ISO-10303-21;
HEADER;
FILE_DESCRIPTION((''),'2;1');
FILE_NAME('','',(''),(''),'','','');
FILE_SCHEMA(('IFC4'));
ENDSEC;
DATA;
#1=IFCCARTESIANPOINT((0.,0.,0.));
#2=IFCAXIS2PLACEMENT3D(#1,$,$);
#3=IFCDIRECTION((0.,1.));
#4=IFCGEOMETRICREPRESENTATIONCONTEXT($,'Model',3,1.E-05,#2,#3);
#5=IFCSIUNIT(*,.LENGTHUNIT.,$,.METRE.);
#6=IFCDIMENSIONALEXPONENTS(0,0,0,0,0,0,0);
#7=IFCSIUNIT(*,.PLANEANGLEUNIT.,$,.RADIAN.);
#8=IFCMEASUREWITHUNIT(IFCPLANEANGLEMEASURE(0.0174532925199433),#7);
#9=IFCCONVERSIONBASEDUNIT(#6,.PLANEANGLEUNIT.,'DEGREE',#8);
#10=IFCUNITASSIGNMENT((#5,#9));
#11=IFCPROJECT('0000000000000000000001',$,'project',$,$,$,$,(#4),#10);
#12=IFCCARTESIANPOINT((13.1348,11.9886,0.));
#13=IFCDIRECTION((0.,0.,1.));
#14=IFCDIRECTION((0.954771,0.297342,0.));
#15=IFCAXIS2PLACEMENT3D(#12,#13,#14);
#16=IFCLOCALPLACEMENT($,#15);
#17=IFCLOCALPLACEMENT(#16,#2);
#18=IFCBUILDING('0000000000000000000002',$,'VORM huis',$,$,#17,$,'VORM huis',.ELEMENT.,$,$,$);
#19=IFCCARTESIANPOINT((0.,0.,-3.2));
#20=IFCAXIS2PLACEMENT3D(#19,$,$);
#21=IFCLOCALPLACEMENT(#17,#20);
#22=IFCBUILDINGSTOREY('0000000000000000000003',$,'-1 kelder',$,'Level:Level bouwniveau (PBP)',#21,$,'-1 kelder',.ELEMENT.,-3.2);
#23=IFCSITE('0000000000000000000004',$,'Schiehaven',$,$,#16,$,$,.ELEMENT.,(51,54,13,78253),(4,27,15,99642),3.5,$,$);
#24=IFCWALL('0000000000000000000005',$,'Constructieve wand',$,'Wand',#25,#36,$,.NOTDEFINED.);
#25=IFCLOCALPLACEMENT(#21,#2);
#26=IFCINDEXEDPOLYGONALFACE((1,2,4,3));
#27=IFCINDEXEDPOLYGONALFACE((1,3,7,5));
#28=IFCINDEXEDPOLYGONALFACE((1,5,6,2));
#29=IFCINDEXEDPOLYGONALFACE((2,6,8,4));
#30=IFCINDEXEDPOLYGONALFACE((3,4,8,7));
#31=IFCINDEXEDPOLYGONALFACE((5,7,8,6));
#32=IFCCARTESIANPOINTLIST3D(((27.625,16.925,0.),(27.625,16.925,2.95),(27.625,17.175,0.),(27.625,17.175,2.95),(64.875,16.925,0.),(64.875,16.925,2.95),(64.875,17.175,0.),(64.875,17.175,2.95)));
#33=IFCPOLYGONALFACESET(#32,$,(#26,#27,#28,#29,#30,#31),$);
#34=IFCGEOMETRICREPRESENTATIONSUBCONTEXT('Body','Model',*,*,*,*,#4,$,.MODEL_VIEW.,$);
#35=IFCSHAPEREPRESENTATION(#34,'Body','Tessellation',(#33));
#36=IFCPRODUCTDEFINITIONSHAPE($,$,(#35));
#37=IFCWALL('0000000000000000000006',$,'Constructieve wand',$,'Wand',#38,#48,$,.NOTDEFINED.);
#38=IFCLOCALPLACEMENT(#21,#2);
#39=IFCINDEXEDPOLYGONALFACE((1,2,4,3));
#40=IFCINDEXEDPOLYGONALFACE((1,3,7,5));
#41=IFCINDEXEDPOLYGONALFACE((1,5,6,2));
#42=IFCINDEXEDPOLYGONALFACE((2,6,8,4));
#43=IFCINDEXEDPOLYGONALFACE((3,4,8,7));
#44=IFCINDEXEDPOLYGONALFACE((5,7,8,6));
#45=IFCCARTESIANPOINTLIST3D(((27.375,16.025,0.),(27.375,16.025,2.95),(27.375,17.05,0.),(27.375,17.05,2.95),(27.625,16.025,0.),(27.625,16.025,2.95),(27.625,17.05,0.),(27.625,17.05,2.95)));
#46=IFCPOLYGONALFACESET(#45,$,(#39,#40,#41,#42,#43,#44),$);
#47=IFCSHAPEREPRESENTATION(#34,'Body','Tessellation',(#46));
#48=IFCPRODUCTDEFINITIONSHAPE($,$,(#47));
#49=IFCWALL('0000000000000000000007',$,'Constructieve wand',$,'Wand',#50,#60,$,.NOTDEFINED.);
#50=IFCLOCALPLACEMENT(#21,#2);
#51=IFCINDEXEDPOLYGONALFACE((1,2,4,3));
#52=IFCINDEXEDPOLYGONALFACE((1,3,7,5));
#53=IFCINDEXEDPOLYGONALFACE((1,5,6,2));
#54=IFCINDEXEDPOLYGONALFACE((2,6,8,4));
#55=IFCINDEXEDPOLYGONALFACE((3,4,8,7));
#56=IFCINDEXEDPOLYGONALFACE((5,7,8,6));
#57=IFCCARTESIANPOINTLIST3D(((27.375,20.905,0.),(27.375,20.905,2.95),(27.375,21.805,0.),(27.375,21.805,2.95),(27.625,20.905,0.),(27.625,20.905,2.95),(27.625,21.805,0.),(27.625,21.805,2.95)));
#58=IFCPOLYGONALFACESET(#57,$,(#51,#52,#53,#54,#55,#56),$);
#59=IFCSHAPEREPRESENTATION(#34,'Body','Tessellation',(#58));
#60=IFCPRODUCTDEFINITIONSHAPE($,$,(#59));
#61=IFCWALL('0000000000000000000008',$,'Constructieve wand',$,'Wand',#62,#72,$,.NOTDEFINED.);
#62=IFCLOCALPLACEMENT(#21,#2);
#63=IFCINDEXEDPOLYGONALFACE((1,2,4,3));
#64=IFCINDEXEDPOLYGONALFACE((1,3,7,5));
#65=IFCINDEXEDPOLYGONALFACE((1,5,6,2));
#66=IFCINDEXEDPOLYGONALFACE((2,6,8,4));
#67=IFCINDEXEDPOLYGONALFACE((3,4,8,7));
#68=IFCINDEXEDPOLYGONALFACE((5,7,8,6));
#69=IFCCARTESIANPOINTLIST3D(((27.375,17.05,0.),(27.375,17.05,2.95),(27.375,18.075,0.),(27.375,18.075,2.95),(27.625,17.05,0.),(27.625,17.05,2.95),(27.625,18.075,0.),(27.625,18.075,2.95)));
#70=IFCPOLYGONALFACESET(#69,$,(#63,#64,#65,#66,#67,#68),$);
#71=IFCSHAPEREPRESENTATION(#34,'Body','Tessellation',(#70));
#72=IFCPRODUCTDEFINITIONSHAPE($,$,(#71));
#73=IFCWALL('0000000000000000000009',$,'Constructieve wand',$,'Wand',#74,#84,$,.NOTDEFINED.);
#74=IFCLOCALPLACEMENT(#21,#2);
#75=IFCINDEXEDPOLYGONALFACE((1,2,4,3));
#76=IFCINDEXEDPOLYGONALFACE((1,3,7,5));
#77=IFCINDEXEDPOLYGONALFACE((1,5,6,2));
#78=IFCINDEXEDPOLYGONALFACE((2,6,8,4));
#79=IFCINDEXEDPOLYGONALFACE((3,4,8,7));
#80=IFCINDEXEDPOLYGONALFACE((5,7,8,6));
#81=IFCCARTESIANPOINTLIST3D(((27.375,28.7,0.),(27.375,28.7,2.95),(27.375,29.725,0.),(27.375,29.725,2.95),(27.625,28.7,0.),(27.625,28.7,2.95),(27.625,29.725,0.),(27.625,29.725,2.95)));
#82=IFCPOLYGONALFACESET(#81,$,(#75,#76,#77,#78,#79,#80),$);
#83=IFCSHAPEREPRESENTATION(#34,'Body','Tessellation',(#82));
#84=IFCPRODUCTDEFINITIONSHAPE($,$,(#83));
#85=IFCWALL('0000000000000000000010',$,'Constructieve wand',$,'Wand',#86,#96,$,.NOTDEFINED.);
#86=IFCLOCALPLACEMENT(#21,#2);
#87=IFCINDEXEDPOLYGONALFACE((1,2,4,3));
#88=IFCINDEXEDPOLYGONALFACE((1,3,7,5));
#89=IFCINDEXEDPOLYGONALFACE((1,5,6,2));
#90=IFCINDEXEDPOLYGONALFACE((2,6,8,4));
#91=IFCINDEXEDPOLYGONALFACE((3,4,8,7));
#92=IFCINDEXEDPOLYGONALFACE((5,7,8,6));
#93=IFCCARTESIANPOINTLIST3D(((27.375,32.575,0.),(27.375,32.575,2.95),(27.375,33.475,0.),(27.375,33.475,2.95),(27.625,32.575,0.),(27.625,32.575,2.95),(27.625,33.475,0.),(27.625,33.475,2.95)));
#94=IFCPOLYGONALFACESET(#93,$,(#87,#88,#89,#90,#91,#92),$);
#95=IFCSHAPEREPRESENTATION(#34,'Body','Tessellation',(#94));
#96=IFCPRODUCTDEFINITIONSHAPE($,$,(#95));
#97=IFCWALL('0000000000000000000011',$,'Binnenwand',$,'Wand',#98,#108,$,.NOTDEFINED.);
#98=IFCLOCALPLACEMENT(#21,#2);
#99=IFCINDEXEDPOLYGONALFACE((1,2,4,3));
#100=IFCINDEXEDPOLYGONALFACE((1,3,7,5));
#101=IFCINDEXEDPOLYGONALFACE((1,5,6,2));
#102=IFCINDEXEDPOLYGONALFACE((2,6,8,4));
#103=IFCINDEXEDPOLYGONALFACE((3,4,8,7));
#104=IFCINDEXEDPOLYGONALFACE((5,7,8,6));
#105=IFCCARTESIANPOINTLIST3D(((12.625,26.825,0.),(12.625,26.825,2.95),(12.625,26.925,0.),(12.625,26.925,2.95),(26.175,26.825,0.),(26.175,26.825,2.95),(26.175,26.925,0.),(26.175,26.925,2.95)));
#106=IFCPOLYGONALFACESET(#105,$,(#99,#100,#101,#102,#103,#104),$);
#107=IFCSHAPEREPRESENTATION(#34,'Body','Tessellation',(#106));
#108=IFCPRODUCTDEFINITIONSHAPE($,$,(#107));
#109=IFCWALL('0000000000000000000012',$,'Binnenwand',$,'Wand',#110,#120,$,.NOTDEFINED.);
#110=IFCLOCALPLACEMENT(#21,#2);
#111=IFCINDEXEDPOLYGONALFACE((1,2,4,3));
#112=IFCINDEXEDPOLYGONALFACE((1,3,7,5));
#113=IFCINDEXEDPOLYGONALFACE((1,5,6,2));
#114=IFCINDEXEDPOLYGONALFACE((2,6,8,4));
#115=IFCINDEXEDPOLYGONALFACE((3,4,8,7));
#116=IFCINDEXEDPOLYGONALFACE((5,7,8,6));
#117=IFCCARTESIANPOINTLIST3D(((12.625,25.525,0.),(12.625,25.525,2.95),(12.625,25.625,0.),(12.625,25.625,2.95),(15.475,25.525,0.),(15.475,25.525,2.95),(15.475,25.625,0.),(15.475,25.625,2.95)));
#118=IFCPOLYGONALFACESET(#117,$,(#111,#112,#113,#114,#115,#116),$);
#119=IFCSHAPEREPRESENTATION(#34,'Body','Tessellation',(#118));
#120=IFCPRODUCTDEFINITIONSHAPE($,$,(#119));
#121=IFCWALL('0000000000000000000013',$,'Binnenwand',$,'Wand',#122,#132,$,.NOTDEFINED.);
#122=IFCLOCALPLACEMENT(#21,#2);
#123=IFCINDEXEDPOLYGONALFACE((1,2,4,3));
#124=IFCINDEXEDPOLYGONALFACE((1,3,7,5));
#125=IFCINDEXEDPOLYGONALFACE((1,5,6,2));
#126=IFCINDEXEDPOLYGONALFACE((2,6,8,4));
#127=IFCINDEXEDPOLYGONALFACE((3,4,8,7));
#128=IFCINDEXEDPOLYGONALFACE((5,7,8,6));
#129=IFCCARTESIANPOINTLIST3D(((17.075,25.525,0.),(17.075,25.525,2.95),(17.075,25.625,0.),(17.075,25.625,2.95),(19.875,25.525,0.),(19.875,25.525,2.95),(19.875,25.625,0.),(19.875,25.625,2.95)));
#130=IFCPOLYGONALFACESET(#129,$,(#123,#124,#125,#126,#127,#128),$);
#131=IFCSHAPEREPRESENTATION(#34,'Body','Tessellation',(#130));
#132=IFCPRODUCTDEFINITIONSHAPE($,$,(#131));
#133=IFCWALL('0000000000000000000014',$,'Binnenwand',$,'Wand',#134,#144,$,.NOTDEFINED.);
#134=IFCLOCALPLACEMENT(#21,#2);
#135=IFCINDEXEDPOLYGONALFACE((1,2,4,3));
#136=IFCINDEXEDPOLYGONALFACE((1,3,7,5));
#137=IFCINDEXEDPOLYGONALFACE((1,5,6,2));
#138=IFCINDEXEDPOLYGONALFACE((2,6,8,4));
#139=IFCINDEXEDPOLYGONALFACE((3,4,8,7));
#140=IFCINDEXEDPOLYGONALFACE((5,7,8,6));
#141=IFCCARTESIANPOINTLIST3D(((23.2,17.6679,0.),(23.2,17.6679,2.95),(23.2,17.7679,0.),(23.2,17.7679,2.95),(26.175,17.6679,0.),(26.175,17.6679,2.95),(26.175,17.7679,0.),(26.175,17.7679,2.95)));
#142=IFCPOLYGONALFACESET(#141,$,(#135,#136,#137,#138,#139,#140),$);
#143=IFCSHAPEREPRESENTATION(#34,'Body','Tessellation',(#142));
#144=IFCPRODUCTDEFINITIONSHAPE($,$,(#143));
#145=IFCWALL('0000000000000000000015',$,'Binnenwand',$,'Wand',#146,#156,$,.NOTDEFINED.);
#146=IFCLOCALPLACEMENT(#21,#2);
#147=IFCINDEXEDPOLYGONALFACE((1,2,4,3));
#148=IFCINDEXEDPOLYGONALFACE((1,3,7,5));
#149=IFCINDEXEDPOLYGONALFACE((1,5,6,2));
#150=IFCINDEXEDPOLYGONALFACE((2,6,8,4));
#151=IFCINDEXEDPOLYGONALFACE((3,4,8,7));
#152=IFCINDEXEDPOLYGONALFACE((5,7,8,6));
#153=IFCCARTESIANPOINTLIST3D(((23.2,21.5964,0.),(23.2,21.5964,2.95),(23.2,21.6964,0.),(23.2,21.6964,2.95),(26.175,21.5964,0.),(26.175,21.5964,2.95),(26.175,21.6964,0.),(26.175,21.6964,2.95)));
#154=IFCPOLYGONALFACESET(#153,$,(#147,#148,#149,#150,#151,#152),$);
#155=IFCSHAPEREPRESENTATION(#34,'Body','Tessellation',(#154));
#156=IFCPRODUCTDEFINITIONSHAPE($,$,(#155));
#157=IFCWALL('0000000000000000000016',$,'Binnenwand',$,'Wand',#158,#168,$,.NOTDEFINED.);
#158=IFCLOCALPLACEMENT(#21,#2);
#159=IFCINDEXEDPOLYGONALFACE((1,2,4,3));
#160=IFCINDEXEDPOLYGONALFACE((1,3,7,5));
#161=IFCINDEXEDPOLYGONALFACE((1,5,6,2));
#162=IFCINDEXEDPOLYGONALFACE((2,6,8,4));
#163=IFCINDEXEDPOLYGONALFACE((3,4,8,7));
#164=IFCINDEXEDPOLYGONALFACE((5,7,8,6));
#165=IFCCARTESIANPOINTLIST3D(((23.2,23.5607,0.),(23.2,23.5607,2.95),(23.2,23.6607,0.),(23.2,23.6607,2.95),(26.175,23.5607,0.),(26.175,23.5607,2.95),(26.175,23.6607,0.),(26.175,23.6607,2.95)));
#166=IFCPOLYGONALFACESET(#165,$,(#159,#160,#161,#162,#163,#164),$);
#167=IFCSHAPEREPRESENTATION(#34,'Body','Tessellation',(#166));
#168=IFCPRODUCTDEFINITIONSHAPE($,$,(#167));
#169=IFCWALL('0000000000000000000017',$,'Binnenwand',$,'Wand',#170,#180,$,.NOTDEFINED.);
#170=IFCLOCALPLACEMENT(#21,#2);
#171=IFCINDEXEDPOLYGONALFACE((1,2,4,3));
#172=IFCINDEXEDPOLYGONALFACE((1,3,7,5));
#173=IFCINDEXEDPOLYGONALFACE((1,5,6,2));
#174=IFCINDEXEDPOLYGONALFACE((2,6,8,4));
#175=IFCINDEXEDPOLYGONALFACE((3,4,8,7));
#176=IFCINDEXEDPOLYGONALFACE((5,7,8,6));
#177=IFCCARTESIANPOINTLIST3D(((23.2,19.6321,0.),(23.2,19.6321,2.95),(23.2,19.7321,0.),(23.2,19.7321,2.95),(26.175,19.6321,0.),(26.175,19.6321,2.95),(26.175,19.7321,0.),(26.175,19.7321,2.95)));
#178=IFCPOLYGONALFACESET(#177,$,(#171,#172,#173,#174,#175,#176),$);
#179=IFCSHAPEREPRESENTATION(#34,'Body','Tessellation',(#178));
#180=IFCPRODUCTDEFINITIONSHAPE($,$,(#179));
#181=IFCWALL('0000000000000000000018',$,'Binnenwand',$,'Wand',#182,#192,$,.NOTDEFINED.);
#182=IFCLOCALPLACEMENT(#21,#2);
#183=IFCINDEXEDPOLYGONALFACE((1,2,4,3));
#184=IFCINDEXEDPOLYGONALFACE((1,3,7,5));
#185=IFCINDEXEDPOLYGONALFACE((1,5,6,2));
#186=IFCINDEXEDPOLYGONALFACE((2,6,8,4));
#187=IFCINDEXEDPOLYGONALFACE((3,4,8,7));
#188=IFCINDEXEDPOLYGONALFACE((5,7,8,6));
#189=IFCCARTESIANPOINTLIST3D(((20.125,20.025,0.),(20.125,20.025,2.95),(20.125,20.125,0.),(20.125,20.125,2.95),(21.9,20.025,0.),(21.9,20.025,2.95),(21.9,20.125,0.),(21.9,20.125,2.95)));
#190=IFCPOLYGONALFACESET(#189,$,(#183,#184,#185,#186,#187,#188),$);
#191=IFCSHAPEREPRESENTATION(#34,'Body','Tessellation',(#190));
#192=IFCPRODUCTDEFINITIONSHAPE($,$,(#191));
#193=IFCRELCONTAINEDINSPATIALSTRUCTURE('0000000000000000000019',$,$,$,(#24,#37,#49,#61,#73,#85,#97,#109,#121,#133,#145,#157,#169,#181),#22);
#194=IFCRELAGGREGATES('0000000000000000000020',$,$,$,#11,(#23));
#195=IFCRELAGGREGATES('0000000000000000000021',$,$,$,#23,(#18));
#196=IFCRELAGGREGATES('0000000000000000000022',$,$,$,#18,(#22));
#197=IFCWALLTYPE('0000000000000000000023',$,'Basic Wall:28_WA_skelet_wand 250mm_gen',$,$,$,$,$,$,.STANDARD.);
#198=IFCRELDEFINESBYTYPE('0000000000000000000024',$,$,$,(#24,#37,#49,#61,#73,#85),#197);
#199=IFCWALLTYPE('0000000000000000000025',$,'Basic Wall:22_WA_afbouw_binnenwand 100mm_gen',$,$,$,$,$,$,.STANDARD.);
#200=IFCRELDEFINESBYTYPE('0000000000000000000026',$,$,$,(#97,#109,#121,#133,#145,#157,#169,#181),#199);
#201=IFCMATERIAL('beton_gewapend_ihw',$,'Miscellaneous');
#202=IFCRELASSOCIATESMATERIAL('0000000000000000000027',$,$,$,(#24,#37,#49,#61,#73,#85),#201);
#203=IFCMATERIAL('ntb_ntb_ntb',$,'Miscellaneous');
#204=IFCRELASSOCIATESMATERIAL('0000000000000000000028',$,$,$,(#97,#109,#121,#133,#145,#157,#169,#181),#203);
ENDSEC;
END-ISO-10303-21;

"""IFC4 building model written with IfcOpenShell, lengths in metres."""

from ifc_helpers import new_model, entity, si_unit, converted_unit, direction, frame, origin, place, context, subcontext, project, spatial, indexed_curve, outline, extrude, material, type_object, element, save


model = new_model("IFC4")

# Units and contexts
model_context = context("Model", 3, precision=1e-05, world=origin(), true_north=direction((0.0, 1.0)))
body_context = subcontext(model_context, "Body", "Model", "MODEL_VIEW")
ifc_project = project(units=[si_unit("LENGTHUNIT", "METRE"), converted_unit("PLANEANGLEUNIT", "DEGREE", entity("IfcPlaneAngleMeasure", 0.0174532925199433), si_unit("PLANEANGLEUNIT", "RADIAN"), dimensions=[0, 0, 0, 0, 0, 0, 0])], contexts=[model_context])

# Site, building, storey
site_placement = place(None, frame((13.1348, 11.9886, 0.0), z_axis=(0.0, 0.0, 1.0), x_axis=(0.954771, 0.297342, 0.0)))
site = spatial("IfcSite", under=ifc_project, at=site_placement, Name="Schiehaven", CompositionType="ELEMENT", RefLatitude=(51, 54, 13, 78253), RefLongitude=(4, 27, 15, 99642), RefElevation=3.5)
building_placement = place(site_placement, origin())
building = spatial("IfcBuilding", under=site, at=building_placement, Name="VORM huis", LongName="VORM huis", CompositionType="ELEMENT")
storey_placement = place(building_placement, frame((0.0, 0.0, -3.2)))
storey = spatial("IfcBuildingStorey", under=building, at=storey_placement, Name="-1 kelder", ObjectType="Level:Level bouwniveau (PBP)", LongName="-1 kelder", CompositionType="ELEMENT", Elevation=-3.2)

# Walls
ifc_material_1 = material(Name="beton_gewapend_ihw", Category="Miscellaneous")
wall_type_1 = type_object("IfcWallType", Name="Basic Wall:28_WA_skelet_wand 250mm_gen", PredefinedType="STANDARD")
wall_1_placement = place(storey_placement, frame((27.625, 17.05, 0.0)))
element("IfcWall", 1, at=wall_1_placement, inside=storey, type_object=wall_type_1, material=ifc_material_1, Name="Constructieve wand", ObjectType="Wand", PredefinedType="NOTDEFINED", context=body_context, shape_type="SweptSolid", body=[
    extrude(outline(indexed_curve([(37.25, 0.125), (0.0, 0.125), (0.0, -0.125), (37.25, -0.125), (37.25, 0.125)], self_intersect=False)), origin(), (0.0, 0.0, 1.0), 2.95),
])
wall_2_placement = place(storey_placement, frame((27.5, 16.025, 0.0), z_axis=(0.0, 0.0, 1.0), x_axis=(0.0, 1.0, 0.0)))
element("IfcWall", 2, at=wall_2_placement, inside=storey, type_object=wall_type_1, material=ifc_material_1, Name="Constructieve wand", ObjectType="Wand", PredefinedType="NOTDEFINED", context=body_context, shape_type="SweptSolid", body=[
    extrude(outline(indexed_curve([(1.025, 0.125), (0.0, 0.125), (0.0, -0.125), (1.025, -0.125), (1.025, 0.125)], self_intersect=False)), origin(), (0.0, 0.0, 1.0), 2.95),
])
wall_3_placement = place(storey_placement, frame((27.5, 21.805, 0.0), z_axis=(0.0, 0.0, 1.0), x_axis=(0.0, -1.0, 0.0)))
element("IfcWall", 3, at=wall_3_placement, inside=storey, type_object=wall_type_1, material=ifc_material_1, Name="Constructieve wand", ObjectType="Wand", PredefinedType="NOTDEFINED", context=body_context, shape_type="SweptSolid", body=[
    extrude(outline(indexed_curve([(0.9, 0.125), (0.0, 0.125), (0.0, -0.125), (0.9, -0.125), (0.9, 0.125)], self_intersect=False)), origin(), (0.0, 0.0, 1.0), 2.95),
])
wall_4_placement = place(storey_placement, frame((27.5, 18.075, 0.0), z_axis=(0.0, 0.0, 1.0), x_axis=(0.0, -1.0, 0.0)))
element("IfcWall", 4, at=wall_4_placement, inside=storey, type_object=wall_type_1, material=ifc_material_1, Name="Constructieve wand", ObjectType="Wand", PredefinedType="NOTDEFINED", context=body_context, shape_type="SweptSolid", body=[
    extrude(outline(indexed_curve([(1.025, 0.125), (0.0, 0.125), (0.0, -0.125), (1.025, -0.125), (1.025, 0.125)], self_intersect=False)), origin(), (0.0, 0.0, 1.0), 2.95),
])
wall_5_placement = place(storey_placement, frame((27.5, 29.725, 0.0), z_axis=(0.0, 0.0, 1.0), x_axis=(0.0, -1.0, 0.0)))
element("IfcWall", 5, at=wall_5_placement, inside=storey, type_object=wall_type_1, material=ifc_material_1, Name="Constructieve wand", ObjectType="Wand", PredefinedType="NOTDEFINED", context=body_context, shape_type="SweptSolid", body=[
    extrude(outline(indexed_curve([(1.025, 0.125), (0.0, 0.125), (0.0, -0.125), (1.025, -0.125), (1.025, 0.125)], self_intersect=False)), origin(), (0.0, 0.0, 1.0), 2.95),
])
wall_6_placement = place(storey_placement, frame((27.5, 32.575, 0.0), z_axis=(0.0, 0.0, 1.0), x_axis=(0.0, 1.0, 0.0)))
element("IfcWall", 6, at=wall_6_placement, inside=storey, type_object=wall_type_1, material=ifc_material_1, Name="Constructieve wand", ObjectType="Wand", PredefinedType="NOTDEFINED", context=body_context, shape_type="SweptSolid", body=[
    extrude(outline(indexed_curve([(0.9, 0.125), (0.0, 0.125), (0.0, -0.125), (0.9, -0.125), (0.9, 0.125)], self_intersect=False)), origin(), (0.0, 0.0, 1.0), 2.95),
])
ifc_material_2 = material(Name="ntb_ntb_ntb", Category="Miscellaneous")
wall_type_2 = type_object("IfcWallType", Name="Basic Wall:22_WA_afbouw_binnenwand 100mm_gen", PredefinedType="STANDARD")
wall_7_placement = place(storey_placement, frame((26.175, 26.875, 0.0), z_axis=(0.0, 0.0, 1.0), x_axis=(-1.0, 0.0, 0.0)))
element("IfcWall", 7, at=wall_7_placement, inside=storey, type_object=wall_type_2, material=ifc_material_2, Name="Binnenwand", ObjectType="Wand", PredefinedType="NOTDEFINED", context=body_context, shape_type="SweptSolid", body=[
    extrude(outline(indexed_curve([(13.55, 0.05), (0.0, 0.05), (0.0, -0.05), (13.55, -0.05), (13.55, 0.05)], self_intersect=False)), origin(), (0.0, 0.0, 1.0), 2.95),
])
wall_8_placement = place(storey_placement, frame((15.475, 25.575, 0.0), z_axis=(0.0, 0.0, 1.0), x_axis=(-1.0, 0.0, 0.0)))
element("IfcWall", 8, at=wall_8_placement, inside=storey, type_object=wall_type_2, material=ifc_material_2, Name="Binnenwand", ObjectType="Wand", PredefinedType="NOTDEFINED", context=body_context, shape_type="SweptSolid", body=[
    extrude(outline(indexed_curve([(2.85, 0.05), (0.0, 0.05), (0.0, -0.05), (2.85, -0.05), (2.85, 0.05)], self_intersect=False)), origin(), (0.0, 0.0, 1.0), 2.95),
])
wall_9_placement = place(storey_placement, frame((19.875, 25.575, 0.0), z_axis=(0.0, 0.0, 1.0), x_axis=(-1.0, 0.0, 0.0)))
element("IfcWall", 9, at=wall_9_placement, inside=storey, type_object=wall_type_2, material=ifc_material_2, Name="Binnenwand", ObjectType="Wand", PredefinedType="NOTDEFINED", context=body_context, shape_type="SweptSolid", body=[
    extrude(outline(indexed_curve([(2.8, 0.05), (0.0, 0.05), (0.0, -0.05), (2.8, -0.05), (2.8, 0.05)], self_intersect=False)), origin(), (0.0, 0.0, 1.0), 2.95),
])
wall_10_placement = place(storey_placement, frame((23.2, 17.7179, 0.0)))
element("IfcWall", 10, at=wall_10_placement, inside=storey, type_object=wall_type_2, material=ifc_material_2, Name="Binnenwand", ObjectType="Wand", PredefinedType="NOTDEFINED", context=body_context, shape_type="SweptSolid", body=[
    extrude(outline(indexed_curve([(2.975, 0.05), (0.0, 0.05), (0.0, -0.05), (2.975, -0.05), (2.975, 0.05)], self_intersect=False)), origin(), (0.0, 0.0, 1.0), 2.95),
])
for number, where, name in (
    (11, (23.2, 21.6464, 0.0), "Binnenwand"),
    (12, (23.2, 23.6107, 0.0), "Binnenwand"),
    (13, (23.2, 19.6821, 0.0), "Binnenwand"),
):
    element("IfcWall", number, at=place(storey_placement, frame(where)), inside=storey, type_object=wall_type_2, material=ifc_material_2, Name=name, ObjectType="Wand", PredefinedType="NOTDEFINED", context=body_context, shape_type="SweptSolid", body=[
        extrude(outline(indexed_curve([(2.975, 0.05), (0.0, 0.05), (0.0, -0.05), (2.975, -0.05), (2.975, 0.05)], self_intersect=False)), origin(), (0.0, 0.0, 1.0), 2.95),
    ])
wall_11_placement = place(storey_placement, frame((21.9, 20.075, 0.0), z_axis=(0.0, 0.0, 1.0), x_axis=(-1.0, 0.0, 0.0)))
element("IfcWall", 14, at=wall_11_placement, inside=storey, type_object=wall_type_2, material=ifc_material_2, Name="Binnenwand", ObjectType="Wand", PredefinedType="NOTDEFINED", context=body_context, shape_type="SweptSolid", body=[
    extrude(outline(indexed_curve([(1.775, 0.05), (0.0, 0.05), (0.0, -0.05), (1.775, -0.05), (1.775, 0.05)], self_intersect=False)), origin(), (0.0, 0.0, 1.0), 2.95),
])

save(model, "model.ifc")
